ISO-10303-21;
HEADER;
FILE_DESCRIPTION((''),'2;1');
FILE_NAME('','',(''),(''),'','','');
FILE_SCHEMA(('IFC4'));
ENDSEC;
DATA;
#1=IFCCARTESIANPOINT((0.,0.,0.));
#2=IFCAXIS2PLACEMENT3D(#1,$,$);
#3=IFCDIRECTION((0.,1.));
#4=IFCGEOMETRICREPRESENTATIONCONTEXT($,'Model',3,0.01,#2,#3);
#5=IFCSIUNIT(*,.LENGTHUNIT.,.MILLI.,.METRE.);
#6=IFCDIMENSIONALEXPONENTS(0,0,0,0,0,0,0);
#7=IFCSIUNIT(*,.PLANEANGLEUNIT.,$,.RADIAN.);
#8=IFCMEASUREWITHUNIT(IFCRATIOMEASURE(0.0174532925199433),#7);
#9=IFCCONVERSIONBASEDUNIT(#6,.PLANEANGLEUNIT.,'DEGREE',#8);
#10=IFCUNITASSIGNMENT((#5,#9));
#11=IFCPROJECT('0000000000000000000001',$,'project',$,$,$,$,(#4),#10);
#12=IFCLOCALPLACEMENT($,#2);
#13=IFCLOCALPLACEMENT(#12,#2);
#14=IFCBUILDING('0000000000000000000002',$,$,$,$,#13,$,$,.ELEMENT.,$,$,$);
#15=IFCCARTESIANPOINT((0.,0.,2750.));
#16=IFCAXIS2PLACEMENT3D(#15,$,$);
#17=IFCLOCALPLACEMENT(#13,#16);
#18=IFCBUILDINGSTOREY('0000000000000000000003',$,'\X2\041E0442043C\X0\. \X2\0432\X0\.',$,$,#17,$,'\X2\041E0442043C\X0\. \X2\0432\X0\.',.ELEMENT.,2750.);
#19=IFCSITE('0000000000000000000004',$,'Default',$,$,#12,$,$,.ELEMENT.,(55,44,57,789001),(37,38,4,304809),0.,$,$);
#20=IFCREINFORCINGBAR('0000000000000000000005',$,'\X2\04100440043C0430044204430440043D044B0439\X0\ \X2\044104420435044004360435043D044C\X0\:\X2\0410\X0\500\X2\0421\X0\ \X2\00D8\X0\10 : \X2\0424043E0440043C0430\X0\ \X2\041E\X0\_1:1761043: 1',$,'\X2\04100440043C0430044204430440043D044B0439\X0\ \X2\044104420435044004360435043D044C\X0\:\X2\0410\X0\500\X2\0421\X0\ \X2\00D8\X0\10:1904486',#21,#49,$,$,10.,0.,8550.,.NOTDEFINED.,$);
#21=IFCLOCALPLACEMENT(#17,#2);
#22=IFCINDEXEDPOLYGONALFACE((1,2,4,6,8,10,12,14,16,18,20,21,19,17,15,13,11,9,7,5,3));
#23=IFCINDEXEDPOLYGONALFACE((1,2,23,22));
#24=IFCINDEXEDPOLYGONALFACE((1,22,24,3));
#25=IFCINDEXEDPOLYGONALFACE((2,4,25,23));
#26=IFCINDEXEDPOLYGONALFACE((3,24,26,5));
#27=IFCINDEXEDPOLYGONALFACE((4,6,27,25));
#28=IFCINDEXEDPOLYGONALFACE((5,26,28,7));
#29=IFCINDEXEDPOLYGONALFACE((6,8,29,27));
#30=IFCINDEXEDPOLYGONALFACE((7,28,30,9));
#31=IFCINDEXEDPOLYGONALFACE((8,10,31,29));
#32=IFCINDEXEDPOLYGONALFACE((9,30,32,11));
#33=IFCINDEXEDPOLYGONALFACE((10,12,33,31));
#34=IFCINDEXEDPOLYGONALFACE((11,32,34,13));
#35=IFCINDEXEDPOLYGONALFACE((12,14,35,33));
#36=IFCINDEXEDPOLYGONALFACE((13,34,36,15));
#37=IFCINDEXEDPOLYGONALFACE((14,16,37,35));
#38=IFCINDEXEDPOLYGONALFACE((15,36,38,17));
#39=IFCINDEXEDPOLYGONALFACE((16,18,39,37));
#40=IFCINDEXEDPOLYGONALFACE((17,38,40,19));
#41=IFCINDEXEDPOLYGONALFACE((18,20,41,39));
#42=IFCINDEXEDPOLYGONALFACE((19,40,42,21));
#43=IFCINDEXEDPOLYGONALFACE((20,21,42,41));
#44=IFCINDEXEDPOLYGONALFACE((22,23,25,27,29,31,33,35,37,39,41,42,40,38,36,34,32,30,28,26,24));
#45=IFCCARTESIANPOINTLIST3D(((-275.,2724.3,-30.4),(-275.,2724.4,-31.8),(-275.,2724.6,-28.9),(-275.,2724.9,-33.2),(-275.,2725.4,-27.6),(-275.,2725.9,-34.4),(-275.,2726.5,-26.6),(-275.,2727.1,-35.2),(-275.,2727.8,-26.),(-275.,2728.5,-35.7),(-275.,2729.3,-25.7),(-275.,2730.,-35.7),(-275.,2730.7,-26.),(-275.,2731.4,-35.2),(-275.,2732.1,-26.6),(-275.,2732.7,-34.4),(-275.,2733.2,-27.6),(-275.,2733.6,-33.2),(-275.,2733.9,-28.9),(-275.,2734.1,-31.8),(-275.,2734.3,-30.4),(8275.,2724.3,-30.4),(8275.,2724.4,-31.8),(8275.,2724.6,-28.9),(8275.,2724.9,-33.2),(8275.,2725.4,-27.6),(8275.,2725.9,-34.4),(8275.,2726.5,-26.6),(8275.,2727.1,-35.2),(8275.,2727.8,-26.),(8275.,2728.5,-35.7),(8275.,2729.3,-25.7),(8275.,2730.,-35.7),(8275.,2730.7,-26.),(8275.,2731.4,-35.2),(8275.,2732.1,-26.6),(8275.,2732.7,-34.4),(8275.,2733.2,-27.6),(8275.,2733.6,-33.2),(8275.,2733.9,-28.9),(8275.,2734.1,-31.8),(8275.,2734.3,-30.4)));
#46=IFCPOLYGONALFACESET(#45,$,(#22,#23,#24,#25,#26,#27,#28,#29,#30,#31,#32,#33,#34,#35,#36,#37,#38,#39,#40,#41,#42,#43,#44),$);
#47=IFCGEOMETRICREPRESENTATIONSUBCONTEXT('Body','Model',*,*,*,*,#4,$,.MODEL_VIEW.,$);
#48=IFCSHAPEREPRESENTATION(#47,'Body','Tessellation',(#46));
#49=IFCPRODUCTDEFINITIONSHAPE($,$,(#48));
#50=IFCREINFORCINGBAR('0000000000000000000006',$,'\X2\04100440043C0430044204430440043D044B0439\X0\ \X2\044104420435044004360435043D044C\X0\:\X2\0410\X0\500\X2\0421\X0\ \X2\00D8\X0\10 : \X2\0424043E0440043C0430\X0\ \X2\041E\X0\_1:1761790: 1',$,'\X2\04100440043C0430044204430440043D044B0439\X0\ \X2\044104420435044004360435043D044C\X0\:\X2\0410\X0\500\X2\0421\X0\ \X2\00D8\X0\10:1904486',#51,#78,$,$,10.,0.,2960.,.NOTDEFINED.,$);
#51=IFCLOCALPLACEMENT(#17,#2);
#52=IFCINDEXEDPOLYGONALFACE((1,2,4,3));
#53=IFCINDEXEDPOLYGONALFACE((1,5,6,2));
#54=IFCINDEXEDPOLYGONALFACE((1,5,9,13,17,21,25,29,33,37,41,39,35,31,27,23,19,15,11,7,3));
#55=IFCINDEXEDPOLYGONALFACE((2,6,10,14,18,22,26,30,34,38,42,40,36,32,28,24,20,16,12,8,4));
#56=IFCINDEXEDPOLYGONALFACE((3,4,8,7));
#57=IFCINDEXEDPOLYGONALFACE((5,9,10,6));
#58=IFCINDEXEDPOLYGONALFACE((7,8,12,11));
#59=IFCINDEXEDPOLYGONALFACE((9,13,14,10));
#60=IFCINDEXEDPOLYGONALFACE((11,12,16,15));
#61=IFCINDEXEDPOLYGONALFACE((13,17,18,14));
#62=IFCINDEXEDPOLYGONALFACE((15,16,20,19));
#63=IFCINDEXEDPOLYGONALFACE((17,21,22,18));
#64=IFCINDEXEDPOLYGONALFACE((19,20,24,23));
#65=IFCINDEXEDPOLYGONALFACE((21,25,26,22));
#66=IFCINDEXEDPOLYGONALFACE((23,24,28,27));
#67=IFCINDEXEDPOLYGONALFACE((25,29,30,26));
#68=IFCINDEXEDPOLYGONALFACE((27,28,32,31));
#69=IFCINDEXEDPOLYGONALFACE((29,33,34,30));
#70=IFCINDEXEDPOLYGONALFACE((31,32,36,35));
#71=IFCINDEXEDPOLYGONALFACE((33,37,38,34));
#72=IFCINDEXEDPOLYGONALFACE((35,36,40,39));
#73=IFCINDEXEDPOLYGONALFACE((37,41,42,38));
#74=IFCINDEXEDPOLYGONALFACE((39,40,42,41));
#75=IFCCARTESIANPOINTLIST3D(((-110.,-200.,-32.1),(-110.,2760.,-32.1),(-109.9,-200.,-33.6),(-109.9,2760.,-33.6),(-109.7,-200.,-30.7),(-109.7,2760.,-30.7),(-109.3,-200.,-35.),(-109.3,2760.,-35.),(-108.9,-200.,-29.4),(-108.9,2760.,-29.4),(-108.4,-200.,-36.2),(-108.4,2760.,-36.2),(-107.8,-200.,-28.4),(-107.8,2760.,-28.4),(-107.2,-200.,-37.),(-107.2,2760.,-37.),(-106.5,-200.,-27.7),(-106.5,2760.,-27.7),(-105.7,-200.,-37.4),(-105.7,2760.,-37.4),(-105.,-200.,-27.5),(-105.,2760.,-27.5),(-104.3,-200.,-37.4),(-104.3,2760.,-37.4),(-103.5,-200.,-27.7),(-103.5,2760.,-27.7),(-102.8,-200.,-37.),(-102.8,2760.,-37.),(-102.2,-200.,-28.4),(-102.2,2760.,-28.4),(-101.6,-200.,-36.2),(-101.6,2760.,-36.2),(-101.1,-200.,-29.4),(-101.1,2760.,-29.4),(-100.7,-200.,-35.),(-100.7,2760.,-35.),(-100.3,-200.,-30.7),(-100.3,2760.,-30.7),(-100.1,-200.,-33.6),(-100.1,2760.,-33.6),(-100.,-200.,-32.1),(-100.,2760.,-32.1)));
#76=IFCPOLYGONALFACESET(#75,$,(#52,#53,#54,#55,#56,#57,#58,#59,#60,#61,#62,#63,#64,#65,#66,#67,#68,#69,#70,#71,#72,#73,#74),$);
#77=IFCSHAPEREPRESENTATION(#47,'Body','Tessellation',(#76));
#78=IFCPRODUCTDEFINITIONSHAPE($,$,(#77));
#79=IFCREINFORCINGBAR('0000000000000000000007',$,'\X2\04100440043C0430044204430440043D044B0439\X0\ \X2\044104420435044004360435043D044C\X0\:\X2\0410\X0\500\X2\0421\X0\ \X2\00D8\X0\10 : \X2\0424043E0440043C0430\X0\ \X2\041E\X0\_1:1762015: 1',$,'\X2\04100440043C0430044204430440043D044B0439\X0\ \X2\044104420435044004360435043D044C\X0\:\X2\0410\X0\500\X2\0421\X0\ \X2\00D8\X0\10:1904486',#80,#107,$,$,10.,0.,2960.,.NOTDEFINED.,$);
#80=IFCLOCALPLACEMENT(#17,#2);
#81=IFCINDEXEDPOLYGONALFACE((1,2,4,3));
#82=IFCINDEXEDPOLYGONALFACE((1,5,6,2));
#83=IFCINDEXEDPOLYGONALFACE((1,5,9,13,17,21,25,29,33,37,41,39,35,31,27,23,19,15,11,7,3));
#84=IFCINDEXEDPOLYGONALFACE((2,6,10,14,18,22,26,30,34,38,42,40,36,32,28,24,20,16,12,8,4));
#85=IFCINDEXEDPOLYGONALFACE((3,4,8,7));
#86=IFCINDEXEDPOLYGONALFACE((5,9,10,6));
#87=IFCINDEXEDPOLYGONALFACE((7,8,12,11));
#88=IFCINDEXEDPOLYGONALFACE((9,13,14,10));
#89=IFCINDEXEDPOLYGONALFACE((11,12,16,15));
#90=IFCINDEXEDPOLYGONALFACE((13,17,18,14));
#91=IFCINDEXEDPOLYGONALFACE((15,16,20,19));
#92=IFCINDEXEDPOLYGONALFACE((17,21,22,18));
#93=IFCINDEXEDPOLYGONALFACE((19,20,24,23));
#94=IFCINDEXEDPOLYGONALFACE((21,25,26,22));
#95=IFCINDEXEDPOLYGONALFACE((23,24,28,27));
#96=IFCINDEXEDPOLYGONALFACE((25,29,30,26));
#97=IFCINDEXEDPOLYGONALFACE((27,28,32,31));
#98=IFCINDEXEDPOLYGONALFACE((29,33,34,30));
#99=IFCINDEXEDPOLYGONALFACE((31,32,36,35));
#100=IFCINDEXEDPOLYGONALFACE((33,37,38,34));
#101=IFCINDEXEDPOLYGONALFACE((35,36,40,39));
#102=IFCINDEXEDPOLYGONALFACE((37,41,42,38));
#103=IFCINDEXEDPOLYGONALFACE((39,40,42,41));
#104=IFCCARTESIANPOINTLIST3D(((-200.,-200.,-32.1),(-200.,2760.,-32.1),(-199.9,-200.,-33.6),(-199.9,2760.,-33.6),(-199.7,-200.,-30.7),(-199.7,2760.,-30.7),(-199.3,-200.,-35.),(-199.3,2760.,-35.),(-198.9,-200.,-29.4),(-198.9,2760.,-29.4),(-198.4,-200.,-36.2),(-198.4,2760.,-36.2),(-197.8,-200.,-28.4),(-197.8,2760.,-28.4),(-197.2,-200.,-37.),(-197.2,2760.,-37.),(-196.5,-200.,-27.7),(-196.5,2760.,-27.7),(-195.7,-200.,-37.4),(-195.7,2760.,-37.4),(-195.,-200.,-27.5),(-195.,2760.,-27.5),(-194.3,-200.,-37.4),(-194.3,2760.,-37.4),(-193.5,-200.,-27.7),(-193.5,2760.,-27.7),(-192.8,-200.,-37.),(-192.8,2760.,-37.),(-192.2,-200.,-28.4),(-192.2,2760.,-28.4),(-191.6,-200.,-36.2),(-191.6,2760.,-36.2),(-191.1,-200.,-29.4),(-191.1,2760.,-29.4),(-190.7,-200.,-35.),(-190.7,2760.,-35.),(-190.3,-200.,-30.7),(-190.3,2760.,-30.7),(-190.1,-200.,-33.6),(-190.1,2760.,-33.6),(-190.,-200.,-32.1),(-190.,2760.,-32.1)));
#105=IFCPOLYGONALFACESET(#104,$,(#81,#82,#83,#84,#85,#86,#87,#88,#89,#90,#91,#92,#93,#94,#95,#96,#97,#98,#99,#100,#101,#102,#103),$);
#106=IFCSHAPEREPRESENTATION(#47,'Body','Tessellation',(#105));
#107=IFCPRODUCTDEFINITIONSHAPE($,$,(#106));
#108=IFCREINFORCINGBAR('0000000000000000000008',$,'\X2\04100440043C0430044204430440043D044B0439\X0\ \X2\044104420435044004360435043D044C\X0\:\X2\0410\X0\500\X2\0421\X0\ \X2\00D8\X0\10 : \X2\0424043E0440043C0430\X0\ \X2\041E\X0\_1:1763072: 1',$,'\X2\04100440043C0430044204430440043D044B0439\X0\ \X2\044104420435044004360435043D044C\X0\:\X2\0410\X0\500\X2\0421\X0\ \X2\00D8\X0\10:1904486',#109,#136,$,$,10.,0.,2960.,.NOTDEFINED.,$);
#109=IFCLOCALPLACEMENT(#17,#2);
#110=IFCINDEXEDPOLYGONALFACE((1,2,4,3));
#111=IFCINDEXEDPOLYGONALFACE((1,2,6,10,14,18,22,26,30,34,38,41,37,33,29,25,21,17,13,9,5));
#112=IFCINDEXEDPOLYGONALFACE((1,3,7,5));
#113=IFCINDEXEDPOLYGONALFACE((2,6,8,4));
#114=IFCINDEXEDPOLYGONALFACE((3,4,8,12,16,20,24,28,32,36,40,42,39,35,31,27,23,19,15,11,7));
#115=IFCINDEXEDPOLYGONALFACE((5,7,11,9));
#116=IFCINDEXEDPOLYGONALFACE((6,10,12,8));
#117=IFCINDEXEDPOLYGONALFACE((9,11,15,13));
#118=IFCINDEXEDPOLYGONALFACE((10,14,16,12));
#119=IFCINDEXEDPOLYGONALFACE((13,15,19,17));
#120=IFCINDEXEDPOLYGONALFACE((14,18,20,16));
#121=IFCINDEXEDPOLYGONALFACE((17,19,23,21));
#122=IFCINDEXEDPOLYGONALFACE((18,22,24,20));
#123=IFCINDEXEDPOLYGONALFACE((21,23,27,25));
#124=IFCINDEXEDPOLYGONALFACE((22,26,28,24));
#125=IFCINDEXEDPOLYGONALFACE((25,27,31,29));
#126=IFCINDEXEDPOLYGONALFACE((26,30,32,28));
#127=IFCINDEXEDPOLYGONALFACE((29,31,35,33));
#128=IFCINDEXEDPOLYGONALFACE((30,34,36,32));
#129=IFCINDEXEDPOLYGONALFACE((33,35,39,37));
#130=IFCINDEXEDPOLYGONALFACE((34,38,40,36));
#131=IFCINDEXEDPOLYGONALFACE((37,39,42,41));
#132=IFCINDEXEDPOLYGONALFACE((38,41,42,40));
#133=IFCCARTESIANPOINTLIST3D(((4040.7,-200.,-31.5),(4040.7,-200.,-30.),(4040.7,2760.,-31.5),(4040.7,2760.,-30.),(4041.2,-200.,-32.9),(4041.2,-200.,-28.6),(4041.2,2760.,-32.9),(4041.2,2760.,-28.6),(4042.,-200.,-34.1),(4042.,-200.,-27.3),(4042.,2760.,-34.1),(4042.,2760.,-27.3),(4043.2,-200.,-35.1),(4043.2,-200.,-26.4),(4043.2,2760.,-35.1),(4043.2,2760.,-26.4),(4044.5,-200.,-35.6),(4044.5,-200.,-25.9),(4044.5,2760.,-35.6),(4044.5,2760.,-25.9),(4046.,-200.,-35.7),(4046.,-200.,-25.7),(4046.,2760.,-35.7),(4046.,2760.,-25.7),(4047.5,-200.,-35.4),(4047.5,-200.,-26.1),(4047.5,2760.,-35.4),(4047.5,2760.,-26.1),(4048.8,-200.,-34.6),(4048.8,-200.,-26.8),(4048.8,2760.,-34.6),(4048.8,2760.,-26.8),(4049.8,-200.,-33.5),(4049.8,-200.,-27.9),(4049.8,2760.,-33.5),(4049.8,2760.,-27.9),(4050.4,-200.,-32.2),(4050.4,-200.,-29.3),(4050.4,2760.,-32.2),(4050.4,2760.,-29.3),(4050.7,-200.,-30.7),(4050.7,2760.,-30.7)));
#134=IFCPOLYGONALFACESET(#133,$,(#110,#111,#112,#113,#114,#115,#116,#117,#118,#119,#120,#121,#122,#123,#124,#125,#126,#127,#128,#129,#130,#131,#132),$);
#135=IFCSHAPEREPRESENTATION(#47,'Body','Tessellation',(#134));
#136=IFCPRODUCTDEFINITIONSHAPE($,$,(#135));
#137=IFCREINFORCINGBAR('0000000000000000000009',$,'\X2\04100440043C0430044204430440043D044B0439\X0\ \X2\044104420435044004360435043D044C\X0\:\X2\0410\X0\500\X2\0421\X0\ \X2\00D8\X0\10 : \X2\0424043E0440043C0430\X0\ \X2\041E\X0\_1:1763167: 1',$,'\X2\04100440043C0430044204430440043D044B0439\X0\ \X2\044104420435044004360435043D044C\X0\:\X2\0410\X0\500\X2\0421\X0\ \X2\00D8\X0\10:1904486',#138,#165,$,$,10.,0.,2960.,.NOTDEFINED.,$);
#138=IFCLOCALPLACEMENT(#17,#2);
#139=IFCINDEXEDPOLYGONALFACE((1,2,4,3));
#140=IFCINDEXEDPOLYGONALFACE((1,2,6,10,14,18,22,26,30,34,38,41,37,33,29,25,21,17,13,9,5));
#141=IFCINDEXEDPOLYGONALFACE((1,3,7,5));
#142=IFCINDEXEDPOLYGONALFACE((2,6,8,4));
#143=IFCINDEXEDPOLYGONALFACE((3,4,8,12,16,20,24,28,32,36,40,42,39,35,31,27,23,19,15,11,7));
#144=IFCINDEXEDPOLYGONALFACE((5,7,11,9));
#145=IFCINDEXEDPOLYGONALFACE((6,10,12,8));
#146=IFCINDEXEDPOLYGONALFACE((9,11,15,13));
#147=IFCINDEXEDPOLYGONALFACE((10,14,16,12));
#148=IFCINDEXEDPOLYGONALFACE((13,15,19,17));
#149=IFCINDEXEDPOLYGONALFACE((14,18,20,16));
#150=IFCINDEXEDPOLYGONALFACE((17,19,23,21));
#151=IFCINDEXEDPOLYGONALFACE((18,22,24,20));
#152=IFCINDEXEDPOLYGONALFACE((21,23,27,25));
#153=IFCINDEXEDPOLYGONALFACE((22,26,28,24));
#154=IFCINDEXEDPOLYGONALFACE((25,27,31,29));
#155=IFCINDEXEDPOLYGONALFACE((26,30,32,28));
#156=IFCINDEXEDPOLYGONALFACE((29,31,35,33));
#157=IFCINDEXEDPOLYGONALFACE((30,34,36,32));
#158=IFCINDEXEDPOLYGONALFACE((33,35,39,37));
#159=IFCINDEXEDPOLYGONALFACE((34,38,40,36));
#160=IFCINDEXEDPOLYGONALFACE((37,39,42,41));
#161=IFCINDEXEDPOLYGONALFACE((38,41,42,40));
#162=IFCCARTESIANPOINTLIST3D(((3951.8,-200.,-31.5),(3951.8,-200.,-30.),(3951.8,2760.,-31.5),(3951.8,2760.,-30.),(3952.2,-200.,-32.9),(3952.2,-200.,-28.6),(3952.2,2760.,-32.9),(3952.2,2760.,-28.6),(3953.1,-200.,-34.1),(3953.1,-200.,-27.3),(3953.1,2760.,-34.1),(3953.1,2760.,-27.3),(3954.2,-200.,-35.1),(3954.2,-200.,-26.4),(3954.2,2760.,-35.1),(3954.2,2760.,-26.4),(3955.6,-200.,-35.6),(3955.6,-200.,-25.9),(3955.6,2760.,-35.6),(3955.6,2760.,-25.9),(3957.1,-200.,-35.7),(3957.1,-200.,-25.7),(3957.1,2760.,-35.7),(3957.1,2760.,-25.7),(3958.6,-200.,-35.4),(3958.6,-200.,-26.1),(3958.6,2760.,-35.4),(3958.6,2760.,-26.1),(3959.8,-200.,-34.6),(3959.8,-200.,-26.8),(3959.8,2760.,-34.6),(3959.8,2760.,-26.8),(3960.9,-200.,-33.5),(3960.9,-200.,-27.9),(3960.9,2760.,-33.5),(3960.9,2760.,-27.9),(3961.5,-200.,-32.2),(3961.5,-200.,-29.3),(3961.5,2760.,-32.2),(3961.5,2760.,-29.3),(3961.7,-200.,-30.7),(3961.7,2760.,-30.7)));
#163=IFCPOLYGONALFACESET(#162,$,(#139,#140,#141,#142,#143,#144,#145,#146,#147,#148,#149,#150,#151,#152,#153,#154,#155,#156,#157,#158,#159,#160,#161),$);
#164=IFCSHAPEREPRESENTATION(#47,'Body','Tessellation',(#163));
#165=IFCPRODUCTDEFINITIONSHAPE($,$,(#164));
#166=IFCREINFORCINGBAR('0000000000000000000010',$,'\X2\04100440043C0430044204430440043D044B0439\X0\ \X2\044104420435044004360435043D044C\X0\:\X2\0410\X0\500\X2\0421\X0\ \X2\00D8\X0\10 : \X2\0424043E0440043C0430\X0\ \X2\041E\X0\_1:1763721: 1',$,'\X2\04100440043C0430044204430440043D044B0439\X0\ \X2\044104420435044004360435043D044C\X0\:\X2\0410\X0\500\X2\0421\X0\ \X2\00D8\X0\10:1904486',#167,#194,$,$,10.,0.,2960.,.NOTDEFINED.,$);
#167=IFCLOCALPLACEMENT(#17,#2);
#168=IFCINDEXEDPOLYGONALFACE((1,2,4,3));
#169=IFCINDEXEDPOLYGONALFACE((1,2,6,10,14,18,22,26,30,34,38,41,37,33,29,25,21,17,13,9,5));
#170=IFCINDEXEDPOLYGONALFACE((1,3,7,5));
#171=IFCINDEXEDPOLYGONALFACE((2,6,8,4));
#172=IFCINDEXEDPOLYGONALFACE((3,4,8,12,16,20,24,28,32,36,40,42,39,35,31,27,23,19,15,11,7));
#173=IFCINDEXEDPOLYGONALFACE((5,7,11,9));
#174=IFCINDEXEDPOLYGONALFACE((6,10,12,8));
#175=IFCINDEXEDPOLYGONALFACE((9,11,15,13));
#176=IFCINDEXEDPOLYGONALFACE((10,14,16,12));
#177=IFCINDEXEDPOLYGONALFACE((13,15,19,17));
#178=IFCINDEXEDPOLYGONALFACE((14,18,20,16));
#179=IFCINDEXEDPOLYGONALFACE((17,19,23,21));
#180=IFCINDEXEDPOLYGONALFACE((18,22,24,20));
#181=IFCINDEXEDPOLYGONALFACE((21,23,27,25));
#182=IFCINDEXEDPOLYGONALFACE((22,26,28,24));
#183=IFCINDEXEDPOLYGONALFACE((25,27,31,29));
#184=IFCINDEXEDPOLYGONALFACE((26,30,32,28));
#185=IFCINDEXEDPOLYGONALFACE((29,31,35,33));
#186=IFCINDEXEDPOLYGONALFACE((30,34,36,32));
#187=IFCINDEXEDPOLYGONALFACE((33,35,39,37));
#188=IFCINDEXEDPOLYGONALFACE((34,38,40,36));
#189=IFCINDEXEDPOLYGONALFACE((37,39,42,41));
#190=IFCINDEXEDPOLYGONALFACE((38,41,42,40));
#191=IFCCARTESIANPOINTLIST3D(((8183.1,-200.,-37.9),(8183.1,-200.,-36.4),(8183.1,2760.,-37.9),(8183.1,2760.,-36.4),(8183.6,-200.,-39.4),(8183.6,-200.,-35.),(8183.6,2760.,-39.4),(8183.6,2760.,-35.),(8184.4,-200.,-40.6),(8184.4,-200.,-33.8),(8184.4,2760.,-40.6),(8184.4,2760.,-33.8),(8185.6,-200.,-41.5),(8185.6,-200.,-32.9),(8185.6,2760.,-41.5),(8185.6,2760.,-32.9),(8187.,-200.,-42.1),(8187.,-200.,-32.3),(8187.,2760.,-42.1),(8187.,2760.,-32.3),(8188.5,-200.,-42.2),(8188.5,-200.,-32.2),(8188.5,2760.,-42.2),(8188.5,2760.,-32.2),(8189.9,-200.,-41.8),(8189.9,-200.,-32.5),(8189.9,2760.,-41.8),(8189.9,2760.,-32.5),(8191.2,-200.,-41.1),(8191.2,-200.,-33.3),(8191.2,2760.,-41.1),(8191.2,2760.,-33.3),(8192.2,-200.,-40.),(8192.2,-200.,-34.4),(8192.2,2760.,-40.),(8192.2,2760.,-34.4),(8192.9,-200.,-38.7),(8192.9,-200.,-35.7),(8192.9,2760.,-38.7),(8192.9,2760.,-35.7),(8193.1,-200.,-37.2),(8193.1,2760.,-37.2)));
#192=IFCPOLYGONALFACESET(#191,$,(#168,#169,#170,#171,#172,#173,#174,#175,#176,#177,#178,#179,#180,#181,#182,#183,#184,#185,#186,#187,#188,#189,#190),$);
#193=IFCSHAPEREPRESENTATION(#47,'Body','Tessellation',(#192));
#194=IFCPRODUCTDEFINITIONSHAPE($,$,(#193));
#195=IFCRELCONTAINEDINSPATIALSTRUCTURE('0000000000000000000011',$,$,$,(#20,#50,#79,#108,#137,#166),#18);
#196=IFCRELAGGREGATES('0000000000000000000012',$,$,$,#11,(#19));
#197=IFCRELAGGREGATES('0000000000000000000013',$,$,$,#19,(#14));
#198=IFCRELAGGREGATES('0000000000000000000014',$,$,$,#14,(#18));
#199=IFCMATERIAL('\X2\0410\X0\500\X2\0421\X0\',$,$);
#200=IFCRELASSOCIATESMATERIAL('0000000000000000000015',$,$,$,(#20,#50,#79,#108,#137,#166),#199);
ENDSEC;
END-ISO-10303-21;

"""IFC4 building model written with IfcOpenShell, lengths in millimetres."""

from ifc_helpers import new_model, entity, si_unit, converted_unit, direction, frame, origin, place, context, subcontext, project, spatial, material, element, save


model = new_model("IFC4")

# Units and contexts
model_context = context("Model", 3, precision=0.01, world=origin(), true_north=direction((0.0, 1.0)))
body_context = subcontext(model_context, "Body", "Model", "MODEL_VIEW")
ifc_project = project(units=[si_unit("LENGTHUNIT", "METRE", prefix="MILLI"), converted_unit("PLANEANGLEUNIT", "DEGREE", entity("IfcRatioMeasure", 0.0174532925199433), si_unit("PLANEANGLEUNIT", "RADIAN"), dimensions=[0, 0, 0, 0, 0, 0, 0])], contexts=[model_context])

# Site, building, storey
site_placement = place(None, origin())
site = spatial("IfcSite", under=ifc_project, at=site_placement, Name="Default", CompositionType="ELEMENT", RefLatitude=(55, 44, 57, 789001), RefLongitude=(37, 38, 4, 304809), RefElevation=0.0)
building_placement = place(site_placement, origin())
building = spatial("IfcBuilding", under=site, at=building_placement, CompositionType="ELEMENT")
storey_placement = place(building_placement, frame((0.0, 0.0, 2750.0)))
storey = spatial("IfcBuildingStorey", under=building, at=storey_placement, Name="Отм. в.", LongName="Отм. в.", CompositionType="ELEMENT", Elevation=2750.0)

# Reinforcing bars
ifc_material_1 = material(Name="А500С")
reinforcing_bar_1_placement = place(storey_placement, origin())
element("IfcReinforcingBar", 1, at=reinforcing_bar_1_placement, inside=storey, material=ifc_material_1, Name="Арматурный стержень:А500С Ø10 : Форма О_1:1761043: 1", ObjectType="Арматурный стержень:А500С Ø10:1904486", BarLength=8550.0, CrossSectionArea=0.0, NominalDiameter=10.0, PredefinedType="NOTDEFINED", context=body_context, shape_type="AdvancedSweptSolid", body=[
    entity("IfcSweptDiskSolid", entity("IfcCompositeCurve", [entity("IfcCompositeCurveSegment", "CONTINUOUS", True, entity("IfcPolyline", [entity("IfcCartesianPoint", [-275.0, 2729.3, -30.7]), entity("IfcCartesianPoint", [8275.0, 2729.3, -30.7])]))], False), 5.0, None, 0.0, 1.0),
])
reinforcing_bar_2_placement = place(storey_placement, origin())
element("IfcReinforcingBar", 2, at=reinforcing_bar_2_placement, inside=storey, material=ifc_material_1, Name="Арматурный стержень:А500С Ø10 : Форма О_1:1761790: 1", ObjectType="Арматурный стержень:А500С Ø10:1904486", BarLength=2960.0, CrossSectionArea=0.0, NominalDiameter=10.0, PredefinedType="NOTDEFINED", context=body_context, shape_type="AdvancedSweptSolid", body=[
    entity("IfcSweptDiskSolid", entity("IfcCompositeCurve", [entity("IfcCompositeCurveSegment", "CONTINUOUS", True, entity("IfcPolyline", [entity("IfcCartesianPoint", [-105.0, -200.0, -32.5]), entity("IfcCartesianPoint", [-105.0, 2760.0, -32.5])]))], False), 5.0, None, 0.0, 1.0),
])
reinforcing_bar_3_placement = place(storey_placement, origin())
element("IfcReinforcingBar", 3, at=reinforcing_bar_3_placement, inside=storey, material=ifc_material_1, Name="Арматурный стержень:А500С Ø10 : Форма О_1:1762015: 1", ObjectType="Арматурный стержень:А500С Ø10:1904486", BarLength=2960.0, CrossSectionArea=0.0, NominalDiameter=10.0, PredefinedType="NOTDEFINED", context=body_context, shape_type="AdvancedSweptSolid", body=[
    entity("IfcSweptDiskSolid", entity("IfcCompositeCurve", [entity("IfcCompositeCurveSegment", "CONTINUOUS", True, entity("IfcPolyline", [entity("IfcCartesianPoint", [-195.0, -200.0, -32.5]), entity("IfcCartesianPoint", [-195.0, 2760.0, -32.5])]))], False), 5.0, None, 0.0, 1.0),
])
reinforcing_bar_4_placement = place(storey_placement, origin())
element("IfcReinforcingBar", 4, at=reinforcing_bar_4_placement, inside=storey, material=ifc_material_1, Name="Арматурный стержень:А500С Ø10 : Форма О_1:1763072: 1", ObjectType="Арматурный стержень:А500С Ø10:1904486", BarLength=2960.0, CrossSectionArea=0.0, NominalDiameter=10.0, PredefinedType="NOTDEFINED", context=body_context, shape_type="AdvancedSweptSolid", body=[
    entity("IfcSweptDiskSolid", entity("IfcCompositeCurve", [entity("IfcCompositeCurveSegment", "CONTINUOUS", True, entity("IfcPolyline", [entity("IfcCartesianPoint", [4045.7, -200.0, -30.7]), entity("IfcCartesianPoint", [4045.7, 2760.0, -30.7])]))], False), 5.0, None, 0.0, 1.0),
])
reinforcing_bar_5_placement = place(storey_placement, origin())
element("IfcReinforcingBar", 5, at=reinforcing_bar_5_placement, inside=storey, material=ifc_material_1, Name="Арматурный стержень:А500С Ø10 : Форма О_1:1763167: 1", ObjectType="Арматурный стержень:А500С Ø10:1904486", BarLength=2960.0, CrossSectionArea=0.0, NominalDiameter=10.0, PredefinedType="NOTDEFINED", context=body_context, shape_type="AdvancedSweptSolid", body=[
    entity("IfcSweptDiskSolid", entity("IfcCompositeCurve", [entity("IfcCompositeCurveSegment", "CONTINUOUS", True, entity("IfcPolyline", [entity("IfcCartesianPoint", [3956.7, -200.0, -30.7]), entity("IfcCartesianPoint", [3956.7, 2760.0, -30.7])]))], False), 5.0, None, 0.0, 1.0),
])
reinforcing_bar_6_placement = place(storey_placement, origin())
element("IfcReinforcingBar", 6, at=reinforcing_bar_6_placement, inside=storey, material=ifc_material_1, Name="Арматурный стержень:А500С Ø10 : Форма О_1:1763721: 1", ObjectType="Арматурный стержень:А500С Ø10:1904486", BarLength=2960.0, CrossSectionArea=0.0, NominalDiameter=10.0, PredefinedType="NOTDEFINED", context=body_context, shape_type="AdvancedSweptSolid", body=[
    entity("IfcSweptDiskSolid", entity("IfcCompositeCurve", [entity("IfcCompositeCurveSegment", "CONTINUOUS", True, entity("IfcPolyline", [entity("IfcCartesianPoint", [8188.1, -200.0, -37.2]), entity("IfcCartesianPoint", [8188.1, 2760.0, -37.2])]))], False), 5.0, None, 0.0, 1.0),
])

save(model, "model.ifc")
